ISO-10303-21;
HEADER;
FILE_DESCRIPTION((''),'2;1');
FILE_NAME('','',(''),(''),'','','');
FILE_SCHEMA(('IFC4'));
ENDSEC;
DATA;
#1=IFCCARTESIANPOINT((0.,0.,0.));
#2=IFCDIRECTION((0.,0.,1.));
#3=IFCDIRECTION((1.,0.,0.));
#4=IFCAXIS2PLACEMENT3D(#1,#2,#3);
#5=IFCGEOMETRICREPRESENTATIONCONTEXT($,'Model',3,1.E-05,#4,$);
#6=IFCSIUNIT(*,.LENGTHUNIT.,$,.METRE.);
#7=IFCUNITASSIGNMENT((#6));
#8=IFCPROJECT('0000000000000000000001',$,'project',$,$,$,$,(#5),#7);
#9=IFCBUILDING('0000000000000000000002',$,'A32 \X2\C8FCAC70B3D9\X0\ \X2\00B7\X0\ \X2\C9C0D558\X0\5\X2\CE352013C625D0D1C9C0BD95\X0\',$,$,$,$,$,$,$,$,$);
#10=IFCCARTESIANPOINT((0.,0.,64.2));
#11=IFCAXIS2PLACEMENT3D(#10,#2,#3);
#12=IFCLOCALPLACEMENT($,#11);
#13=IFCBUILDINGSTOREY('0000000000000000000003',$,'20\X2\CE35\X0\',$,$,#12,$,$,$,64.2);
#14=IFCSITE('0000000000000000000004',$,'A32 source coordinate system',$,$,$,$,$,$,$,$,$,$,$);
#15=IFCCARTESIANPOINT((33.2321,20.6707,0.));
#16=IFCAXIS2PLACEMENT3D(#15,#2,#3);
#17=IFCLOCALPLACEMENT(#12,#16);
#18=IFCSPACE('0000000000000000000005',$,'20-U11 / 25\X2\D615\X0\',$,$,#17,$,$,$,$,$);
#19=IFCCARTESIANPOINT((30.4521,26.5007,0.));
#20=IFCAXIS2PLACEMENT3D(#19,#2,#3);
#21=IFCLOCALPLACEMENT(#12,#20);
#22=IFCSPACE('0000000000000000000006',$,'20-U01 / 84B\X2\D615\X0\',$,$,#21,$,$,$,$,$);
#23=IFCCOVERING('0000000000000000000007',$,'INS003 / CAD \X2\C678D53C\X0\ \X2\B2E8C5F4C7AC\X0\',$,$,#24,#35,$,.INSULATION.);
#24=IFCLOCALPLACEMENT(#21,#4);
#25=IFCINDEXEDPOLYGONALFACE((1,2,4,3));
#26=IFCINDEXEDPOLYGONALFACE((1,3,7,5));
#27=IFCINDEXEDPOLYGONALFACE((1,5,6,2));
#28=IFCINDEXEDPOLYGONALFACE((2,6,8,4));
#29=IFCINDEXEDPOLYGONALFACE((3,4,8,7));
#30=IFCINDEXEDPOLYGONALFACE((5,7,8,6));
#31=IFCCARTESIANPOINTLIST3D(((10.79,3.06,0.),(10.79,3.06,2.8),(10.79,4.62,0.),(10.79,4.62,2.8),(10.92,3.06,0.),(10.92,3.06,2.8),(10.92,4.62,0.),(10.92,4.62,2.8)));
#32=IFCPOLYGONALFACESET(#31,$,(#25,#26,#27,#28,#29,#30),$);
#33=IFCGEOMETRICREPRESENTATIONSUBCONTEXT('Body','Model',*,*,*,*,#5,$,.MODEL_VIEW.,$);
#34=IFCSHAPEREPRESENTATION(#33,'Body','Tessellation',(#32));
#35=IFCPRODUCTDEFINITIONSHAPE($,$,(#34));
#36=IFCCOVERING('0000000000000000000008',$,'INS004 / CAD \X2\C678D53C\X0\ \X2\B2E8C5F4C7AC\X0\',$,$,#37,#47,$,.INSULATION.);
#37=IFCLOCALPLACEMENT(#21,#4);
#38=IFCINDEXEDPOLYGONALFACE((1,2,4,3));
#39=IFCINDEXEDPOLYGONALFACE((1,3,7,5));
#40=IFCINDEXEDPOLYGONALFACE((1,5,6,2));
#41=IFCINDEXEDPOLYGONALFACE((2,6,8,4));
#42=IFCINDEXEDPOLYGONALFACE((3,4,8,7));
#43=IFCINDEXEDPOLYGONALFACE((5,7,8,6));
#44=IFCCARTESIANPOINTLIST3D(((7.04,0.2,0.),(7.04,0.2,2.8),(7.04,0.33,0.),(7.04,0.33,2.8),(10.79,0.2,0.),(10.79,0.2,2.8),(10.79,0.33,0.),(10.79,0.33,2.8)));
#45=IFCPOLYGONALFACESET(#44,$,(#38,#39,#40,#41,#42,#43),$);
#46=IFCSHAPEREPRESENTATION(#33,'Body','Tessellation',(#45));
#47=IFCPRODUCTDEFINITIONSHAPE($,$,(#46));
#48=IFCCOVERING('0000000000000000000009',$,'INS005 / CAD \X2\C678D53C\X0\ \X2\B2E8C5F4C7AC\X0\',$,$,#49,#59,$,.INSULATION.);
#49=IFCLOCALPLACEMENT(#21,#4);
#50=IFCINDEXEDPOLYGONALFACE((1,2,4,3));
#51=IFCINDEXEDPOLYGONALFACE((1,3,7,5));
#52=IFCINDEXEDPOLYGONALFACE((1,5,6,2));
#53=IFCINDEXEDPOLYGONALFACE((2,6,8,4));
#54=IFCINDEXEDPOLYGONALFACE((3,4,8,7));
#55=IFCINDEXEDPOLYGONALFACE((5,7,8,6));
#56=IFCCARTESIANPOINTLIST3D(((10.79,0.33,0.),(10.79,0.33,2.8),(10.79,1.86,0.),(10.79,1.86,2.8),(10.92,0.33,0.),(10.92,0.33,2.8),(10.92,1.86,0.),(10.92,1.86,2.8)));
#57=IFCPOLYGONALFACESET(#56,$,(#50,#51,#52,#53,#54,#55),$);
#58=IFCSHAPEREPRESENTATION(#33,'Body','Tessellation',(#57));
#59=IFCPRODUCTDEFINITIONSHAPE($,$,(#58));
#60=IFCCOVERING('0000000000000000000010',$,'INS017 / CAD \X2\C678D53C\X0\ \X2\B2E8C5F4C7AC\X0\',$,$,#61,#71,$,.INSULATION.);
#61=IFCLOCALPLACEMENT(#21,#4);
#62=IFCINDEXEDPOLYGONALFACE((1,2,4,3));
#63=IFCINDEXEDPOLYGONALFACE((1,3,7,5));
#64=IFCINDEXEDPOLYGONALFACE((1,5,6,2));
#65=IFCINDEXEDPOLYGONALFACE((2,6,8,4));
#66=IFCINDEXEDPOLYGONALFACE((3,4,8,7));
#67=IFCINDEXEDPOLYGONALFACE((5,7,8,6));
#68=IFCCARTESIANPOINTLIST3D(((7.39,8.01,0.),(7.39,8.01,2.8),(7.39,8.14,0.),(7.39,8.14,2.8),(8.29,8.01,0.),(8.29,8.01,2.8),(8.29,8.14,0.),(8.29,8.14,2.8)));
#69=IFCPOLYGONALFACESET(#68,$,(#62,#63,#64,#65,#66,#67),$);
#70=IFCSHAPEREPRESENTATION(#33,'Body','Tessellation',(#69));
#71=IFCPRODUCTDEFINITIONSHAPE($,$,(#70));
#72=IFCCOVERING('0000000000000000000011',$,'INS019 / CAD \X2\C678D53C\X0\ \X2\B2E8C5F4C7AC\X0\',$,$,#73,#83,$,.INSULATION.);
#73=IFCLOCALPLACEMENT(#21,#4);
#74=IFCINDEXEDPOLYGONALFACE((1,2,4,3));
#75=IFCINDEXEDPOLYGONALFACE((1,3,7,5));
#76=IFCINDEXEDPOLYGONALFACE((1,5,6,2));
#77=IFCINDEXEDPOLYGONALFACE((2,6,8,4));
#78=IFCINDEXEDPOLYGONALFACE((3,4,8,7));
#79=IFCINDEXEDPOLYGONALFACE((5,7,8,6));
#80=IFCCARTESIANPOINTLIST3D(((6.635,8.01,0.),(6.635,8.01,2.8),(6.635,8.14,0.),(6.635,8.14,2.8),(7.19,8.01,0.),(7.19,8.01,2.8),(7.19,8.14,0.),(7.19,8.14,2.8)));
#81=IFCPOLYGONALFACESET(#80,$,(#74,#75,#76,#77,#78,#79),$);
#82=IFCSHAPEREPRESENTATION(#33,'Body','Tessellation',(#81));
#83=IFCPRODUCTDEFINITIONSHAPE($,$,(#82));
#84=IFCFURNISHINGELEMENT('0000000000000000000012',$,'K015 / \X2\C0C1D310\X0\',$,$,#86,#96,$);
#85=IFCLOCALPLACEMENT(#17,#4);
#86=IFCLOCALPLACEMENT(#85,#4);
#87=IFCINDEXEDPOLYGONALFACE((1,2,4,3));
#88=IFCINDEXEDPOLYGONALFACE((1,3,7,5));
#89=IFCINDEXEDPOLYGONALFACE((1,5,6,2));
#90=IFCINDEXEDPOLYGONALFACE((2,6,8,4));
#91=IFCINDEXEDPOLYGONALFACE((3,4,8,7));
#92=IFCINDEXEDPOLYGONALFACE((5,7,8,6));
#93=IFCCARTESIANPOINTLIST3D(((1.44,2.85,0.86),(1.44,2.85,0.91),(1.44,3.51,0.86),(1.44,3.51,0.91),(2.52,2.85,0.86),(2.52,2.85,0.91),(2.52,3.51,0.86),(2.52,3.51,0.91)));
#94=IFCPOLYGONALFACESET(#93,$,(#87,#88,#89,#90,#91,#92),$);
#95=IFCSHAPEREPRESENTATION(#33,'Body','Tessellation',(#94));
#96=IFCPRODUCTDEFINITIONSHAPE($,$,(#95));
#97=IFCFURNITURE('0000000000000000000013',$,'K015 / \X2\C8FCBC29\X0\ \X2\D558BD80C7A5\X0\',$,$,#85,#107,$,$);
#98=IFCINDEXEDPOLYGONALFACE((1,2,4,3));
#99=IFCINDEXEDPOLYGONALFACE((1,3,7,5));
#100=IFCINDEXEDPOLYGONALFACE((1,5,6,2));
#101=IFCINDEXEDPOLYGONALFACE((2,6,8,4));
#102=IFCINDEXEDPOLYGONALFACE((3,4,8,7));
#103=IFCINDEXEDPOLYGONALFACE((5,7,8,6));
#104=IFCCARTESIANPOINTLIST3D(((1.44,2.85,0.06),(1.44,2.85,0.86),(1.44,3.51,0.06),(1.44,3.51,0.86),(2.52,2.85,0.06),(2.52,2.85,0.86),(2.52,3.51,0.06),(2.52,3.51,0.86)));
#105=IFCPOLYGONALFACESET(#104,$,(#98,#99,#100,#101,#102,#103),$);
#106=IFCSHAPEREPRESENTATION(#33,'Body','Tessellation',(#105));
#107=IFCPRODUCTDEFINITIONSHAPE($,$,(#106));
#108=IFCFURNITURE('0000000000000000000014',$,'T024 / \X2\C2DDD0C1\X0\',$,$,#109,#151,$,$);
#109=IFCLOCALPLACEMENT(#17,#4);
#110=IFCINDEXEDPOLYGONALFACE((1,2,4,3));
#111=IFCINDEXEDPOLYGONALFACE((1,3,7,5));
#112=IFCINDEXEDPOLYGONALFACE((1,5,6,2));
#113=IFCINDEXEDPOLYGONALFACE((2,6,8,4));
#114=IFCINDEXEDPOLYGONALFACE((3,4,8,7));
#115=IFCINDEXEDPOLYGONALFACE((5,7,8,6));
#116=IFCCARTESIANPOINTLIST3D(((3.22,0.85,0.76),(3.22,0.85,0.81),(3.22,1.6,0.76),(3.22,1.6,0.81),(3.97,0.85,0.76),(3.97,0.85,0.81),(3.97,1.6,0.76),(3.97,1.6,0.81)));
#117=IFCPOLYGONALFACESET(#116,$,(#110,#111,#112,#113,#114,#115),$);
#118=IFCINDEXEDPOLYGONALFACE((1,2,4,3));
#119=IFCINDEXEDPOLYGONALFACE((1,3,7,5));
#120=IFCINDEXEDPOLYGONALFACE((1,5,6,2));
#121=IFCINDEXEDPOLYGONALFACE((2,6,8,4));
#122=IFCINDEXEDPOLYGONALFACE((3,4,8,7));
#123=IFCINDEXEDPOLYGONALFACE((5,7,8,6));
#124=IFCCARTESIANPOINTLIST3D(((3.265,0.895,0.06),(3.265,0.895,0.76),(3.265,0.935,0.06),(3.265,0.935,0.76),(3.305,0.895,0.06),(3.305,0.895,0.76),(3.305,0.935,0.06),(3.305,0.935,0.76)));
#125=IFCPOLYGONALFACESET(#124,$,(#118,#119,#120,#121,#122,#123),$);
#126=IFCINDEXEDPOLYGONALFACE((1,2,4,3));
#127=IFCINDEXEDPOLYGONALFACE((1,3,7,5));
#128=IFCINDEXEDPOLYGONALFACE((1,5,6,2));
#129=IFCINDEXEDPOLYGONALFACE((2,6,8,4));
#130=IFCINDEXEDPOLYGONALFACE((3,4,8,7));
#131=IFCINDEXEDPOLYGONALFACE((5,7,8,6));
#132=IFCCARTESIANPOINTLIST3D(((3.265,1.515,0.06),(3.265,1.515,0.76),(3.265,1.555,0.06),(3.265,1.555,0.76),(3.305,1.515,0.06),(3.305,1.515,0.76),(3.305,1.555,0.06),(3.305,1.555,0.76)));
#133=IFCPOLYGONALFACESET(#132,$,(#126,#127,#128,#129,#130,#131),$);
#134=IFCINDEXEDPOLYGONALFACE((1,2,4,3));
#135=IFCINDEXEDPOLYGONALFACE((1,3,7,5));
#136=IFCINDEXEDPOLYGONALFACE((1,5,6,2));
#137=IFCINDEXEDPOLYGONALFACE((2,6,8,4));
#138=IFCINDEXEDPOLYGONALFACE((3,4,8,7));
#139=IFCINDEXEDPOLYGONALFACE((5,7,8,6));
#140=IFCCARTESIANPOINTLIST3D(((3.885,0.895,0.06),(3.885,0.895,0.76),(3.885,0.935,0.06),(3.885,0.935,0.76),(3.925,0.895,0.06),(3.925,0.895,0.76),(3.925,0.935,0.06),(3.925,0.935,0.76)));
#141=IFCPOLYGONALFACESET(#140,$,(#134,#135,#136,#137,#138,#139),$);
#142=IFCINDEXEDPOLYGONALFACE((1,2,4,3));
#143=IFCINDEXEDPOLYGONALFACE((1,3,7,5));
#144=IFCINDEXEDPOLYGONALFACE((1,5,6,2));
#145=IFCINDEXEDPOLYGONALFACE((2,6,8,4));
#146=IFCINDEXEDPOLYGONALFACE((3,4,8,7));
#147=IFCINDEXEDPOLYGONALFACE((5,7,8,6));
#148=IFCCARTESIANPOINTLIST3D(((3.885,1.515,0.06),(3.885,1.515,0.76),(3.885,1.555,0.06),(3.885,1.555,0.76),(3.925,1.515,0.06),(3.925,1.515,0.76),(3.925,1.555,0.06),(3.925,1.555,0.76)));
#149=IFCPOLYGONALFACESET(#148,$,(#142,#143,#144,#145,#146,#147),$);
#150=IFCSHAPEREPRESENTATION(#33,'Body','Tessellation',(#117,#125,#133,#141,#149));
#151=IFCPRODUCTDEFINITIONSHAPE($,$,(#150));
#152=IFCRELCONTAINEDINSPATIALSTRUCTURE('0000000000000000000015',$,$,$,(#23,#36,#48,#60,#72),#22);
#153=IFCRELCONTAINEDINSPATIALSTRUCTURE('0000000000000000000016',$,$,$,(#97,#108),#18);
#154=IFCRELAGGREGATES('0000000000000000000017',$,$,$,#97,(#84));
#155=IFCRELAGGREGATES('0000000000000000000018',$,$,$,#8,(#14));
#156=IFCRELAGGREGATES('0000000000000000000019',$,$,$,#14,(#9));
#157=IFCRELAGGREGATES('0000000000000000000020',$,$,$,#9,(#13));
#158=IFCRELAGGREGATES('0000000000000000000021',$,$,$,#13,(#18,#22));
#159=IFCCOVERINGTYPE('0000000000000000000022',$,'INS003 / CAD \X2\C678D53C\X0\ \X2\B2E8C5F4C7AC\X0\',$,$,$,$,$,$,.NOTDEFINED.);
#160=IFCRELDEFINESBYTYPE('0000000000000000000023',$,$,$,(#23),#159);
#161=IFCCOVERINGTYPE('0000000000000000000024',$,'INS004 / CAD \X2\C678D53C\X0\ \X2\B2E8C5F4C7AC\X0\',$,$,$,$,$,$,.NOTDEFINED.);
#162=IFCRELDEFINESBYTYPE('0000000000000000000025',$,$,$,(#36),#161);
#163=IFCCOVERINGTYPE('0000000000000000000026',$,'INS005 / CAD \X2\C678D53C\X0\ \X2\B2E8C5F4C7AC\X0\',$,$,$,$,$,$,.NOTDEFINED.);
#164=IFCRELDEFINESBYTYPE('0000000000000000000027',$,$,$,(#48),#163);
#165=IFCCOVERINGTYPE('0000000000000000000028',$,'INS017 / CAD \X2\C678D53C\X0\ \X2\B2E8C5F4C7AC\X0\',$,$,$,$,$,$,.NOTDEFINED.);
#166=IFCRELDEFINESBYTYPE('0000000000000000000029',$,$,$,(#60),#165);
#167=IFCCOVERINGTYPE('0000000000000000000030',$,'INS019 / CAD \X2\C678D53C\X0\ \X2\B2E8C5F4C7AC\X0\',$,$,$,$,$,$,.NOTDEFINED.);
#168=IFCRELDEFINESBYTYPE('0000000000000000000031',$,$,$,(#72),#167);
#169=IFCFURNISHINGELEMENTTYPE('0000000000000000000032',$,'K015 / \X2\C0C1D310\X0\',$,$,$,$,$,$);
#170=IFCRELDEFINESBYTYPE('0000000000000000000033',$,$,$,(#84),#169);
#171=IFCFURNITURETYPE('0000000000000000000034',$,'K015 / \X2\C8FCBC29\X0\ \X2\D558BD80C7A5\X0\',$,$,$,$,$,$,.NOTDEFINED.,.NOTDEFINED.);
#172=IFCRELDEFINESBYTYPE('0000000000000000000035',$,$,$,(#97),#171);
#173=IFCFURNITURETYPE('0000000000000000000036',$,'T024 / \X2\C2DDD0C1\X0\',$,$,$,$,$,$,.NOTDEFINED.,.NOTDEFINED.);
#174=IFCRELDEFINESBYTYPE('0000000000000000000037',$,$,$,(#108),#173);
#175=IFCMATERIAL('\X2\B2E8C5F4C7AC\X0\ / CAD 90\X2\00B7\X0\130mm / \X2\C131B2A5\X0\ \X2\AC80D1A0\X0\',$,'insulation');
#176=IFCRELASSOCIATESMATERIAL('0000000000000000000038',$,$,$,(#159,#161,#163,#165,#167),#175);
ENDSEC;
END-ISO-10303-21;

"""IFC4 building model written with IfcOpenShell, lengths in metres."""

from ifc_helpers import new_model, si_unit, frame, origin, origin_with_axes, place, context, subcontext, project, spatial, polyline, outline, extrude, source, transform, mapped, material, type_object, type_shapes, element, aggregate, save


model = new_model("IFC4")

# Units and contexts
model_context = context("Model", 3, precision=1e-05, world=origin_with_axes())
body_context = subcontext(model_context, "Body", "Model", "MODEL_VIEW")
ifc_project = project(units=[si_unit("LENGTHUNIT", "METRE")], contexts=[model_context])

# Site, building, storey, space
site = spatial("IfcSite", under=ifc_project, Name="A32 source coordinate system")
building = spatial("IfcBuilding", under=site, Name="A32 주거동 · 지하5층–옥탑지붕")
storey_placement = place(None, frame((0.0, 0.0, 64.2), z_axis=(0.0, 0.0, 1.0), x_axis=(1.0, 0.0, 0.0)))
storey = spatial("IfcBuildingStorey", under=building, at=storey_placement, Name="20층", Elevation=64.2)
space_1_placement = place(storey_placement, frame((33.2321, 20.6707, 0.0), z_axis=(0.0, 0.0, 1.0), x_axis=(1.0, 0.0, 0.0)))
space_1 = spatial("IfcSpace", under=storey, at=space_1_placement, Name="20-U11 / 25형")

# Shared definitions
space_2_placement = place(storey_placement, frame((30.4521, 26.5007, 0.0), z_axis=(0.0, 0.0, 1.0), x_axis=(1.0, 0.0, 0.0)))
space_2 = spatial("IfcSpace", under=storey, at=space_2_placement, Name="20-U01 / 84B형")

# Coverings
ifc_material = material(Name="단열재 / CAD 90·130mm / 성능 검토", Category="insulation")
covering_type_1 = type_object("IfcCoveringType", Name="INS003 / CAD 외피 단열재", PredefinedType="NOTDEFINED", material=ifc_material)
shared_shape_1 = source(origin(), body_context, "Body", "SweptSolid", [
    extrude(outline(polyline([(10.79, 3.06), (10.79, 4.62), (10.92, 4.62), (10.92, 3.06), (10.79, 3.06)])), origin(), (0.0, 0.0, 1.0), 2.8),
])
type_shapes(covering_type_1, [shared_shape_1])
covering_1_placement = place(space_2_placement, origin_with_axes())
element("IfcCovering", 1, at=covering_1_placement, inside=space_2, type_object=covering_type_1, Name="INS003 / CAD 외피 단열재", PredefinedType="INSULATION", context=body_context, shape_type="MappedRepresentation", body=[
    mapped(shared_shape_1, transform((0.0, 0.0, 0.0), scale=1.0)),
])
covering_type_2 = type_object("IfcCoveringType", Name="INS004 / CAD 외피 단열재", PredefinedType="NOTDEFINED", material=ifc_material)
shared_shape_2 = source(origin(), body_context, "Body", "SweptSolid", [
    extrude(outline(polyline([(7.04, 0.33), (10.79, 0.33), (10.79, 0.2), (7.04, 0.2), (7.04, 0.33)])), origin(), (0.0, 0.0, 1.0), 2.8),
])
type_shapes(covering_type_2, [shared_shape_2])
covering_2_placement = place(space_2_placement, origin_with_axes())
element("IfcCovering", 2, at=covering_2_placement, inside=space_2, type_object=covering_type_2, Name="INS004 / CAD 외피 단열재", PredefinedType="INSULATION", context=body_context, shape_type="MappedRepresentation", body=[
    mapped(shared_shape_2, transform((0.0, 0.0, 0.0), scale=1.0)),
])
covering_type_3 = type_object("IfcCoveringType", Name="INS005 / CAD 외피 단열재", PredefinedType="NOTDEFINED", material=ifc_material)
shared_shape_3 = source(origin(), body_context, "Body", "SweptSolid", [
    extrude(outline(polyline([(10.79, 0.33), (10.79, 1.86), (10.92, 1.86), (10.92, 0.33), (10.79, 0.33)])), origin(), (0.0, 0.0, 1.0), 2.8),
])
type_shapes(covering_type_3, [shared_shape_3])
covering_3_placement = place(space_2_placement, origin_with_axes())
element("IfcCovering", 3, at=covering_3_placement, inside=space_2, type_object=covering_type_3, Name="INS005 / CAD 외피 단열재", PredefinedType="INSULATION", context=body_context, shape_type="MappedRepresentation", body=[
    mapped(shared_shape_3, transform((0.0, 0.0, 0.0), scale=1.0)),
])
covering_type_4 = type_object("IfcCoveringType", Name="INS017 / CAD 외피 단열재", PredefinedType="NOTDEFINED", material=ifc_material)
shared_shape_4 = source(origin(), body_context, "Body", "SweptSolid", [
    extrude(outline(polyline([(8.29, 8.01), (7.39, 8.01), (7.39, 8.14), (8.29, 8.14), (8.29, 8.01)])), origin(), (0.0, 0.0, 1.0), 2.8),
])
type_shapes(covering_type_4, [shared_shape_4])
covering_4_placement = place(space_2_placement, origin_with_axes())
element("IfcCovering", 4, at=covering_4_placement, inside=space_2, type_object=covering_type_4, Name="INS017 / CAD 외피 단열재", PredefinedType="INSULATION", context=body_context, shape_type="MappedRepresentation", body=[
    mapped(shared_shape_4, transform((0.0, 0.0, 0.0), scale=1.0)),
])
covering_type_5 = type_object("IfcCoveringType", Name="INS019 / CAD 외피 단열재", PredefinedType="NOTDEFINED", material=ifc_material)
shared_shape_5 = source(origin(), body_context, "Body", "SweptSolid", [
    extrude(outline(polyline([(6.635, 8.01), (6.635, 8.14), (7.19, 8.14), (7.19, 8.01), (6.635, 8.01)])), origin(), (0.0, 0.0, 1.0), 2.8),
])
type_shapes(covering_type_5, [shared_shape_5])
covering_5_placement = place(space_2_placement, origin_with_axes())
element("IfcCovering", 5, at=covering_5_placement, inside=space_2, type_object=covering_type_5, Name="INS019 / CAD 외피 단열재", PredefinedType="INSULATION", context=body_context, shape_type="MappedRepresentation", body=[
    mapped(shared_shape_5, transform((0.0, 0.0, 0.0), scale=1.0)),
])

# Furnishing element
furnishing_element_type_1 = type_object("IfcFurnishingElementType", Name="K015 / 상판")
shared_shape_6 = source(origin(), body_context, "Body", "SweptSolid", [
    extrude(outline(polyline([(2.52, 2.85), (1.44, 2.85), (1.44, 3.51), (2.52, 3.51), (2.52, 2.85)])), frame((0.0, 0.0, 0.86)), (0.0, 0.0, 1.0), 0.05),
])
type_shapes(furnishing_element_type_1, [shared_shape_6])
furniture_1_placement = place(space_1_placement, origin_with_axes())
furnishing_1_placement = place(furniture_1_placement, origin_with_axes())
furnishing_1 = element("IfcFurnishingElement", 6, at=furnishing_1_placement, type_object=furnishing_element_type_1, Name="K015 / 상판", context=body_context, shape_type="MappedRepresentation", body=[
    mapped(shared_shape_6, transform((0.0, 0.0, 0.0), scale=1.0)),
])

# Furniture
furniture_type_1 = type_object("IfcFurnitureType", Name="K015 / 주방 하부장", AssemblyPlace="NOTDEFINED", PredefinedType="NOTDEFINED")
shared_shape_7 = source(origin(), body_context, "Body", "SweptSolid", [
    extrude(outline(polyline([(2.52, 3.51), (2.52, 2.85), (1.44, 2.85), (1.44, 3.51), (2.52, 3.51)])), frame((0.0, 0.0, 0.06)), (0.0, 0.0, 1.0), 0.8),
])
type_shapes(furniture_type_1, [shared_shape_7])
furniture_1 = element("IfcFurniture", 7, at=furniture_1_placement, inside=space_1, type_object=furniture_type_1, Name="K015 / 주방 하부장", context=body_context, shape_type="MappedRepresentation", body=[
    mapped(shared_shape_7, transform((0.0, 0.0, 0.0), scale=1.0)),
])
aggregate(furniture_1, [furnishing_1])
furniture_type_2 = type_object("IfcFurnitureType", Name="T024 / 식탁", AssemblyPlace="NOTDEFINED", PredefinedType="NOTDEFINED")
shared_shape_8 = source(origin(), body_context, "Body", "SweptSolid", [
    extrude(outline(polyline([(3.22, 0.85), (3.22, 1.6), (3.97, 1.6), (3.97, 0.85), (3.22, 0.85)])), frame((0.0, 0.0, 0.76)), (0.0, 0.0, 1.0), 0.05),
    extrude(outline(polyline([(3.265, 0.895), (3.265, 0.935), (3.305, 0.935), (3.305, 0.895), (3.265, 0.895)])), frame((0.0, 0.0, 0.06)), (0.0, 0.0, 1.0), 0.7),
    extrude(outline(polyline([(3.265, 1.515), (3.265, 1.555), (3.305, 1.555), (3.305, 1.515), (3.265, 1.515)])), frame((0.0, 0.0, 0.06)), (0.0, 0.0, 1.0), 0.7),
    extrude(outline(polyline([(3.885, 0.895), (3.885, 0.935), (3.925, 0.935), (3.925, 0.895), (3.885, 0.895)])), frame((0.0, 0.0, 0.06)), (0.0, 0.0, 1.0), 0.7),
    extrude(outline(polyline([(3.885, 1.515), (3.885, 1.555), (3.925, 1.555), (3.925, 1.515), (3.885, 1.515)])), frame((0.0, 0.0, 0.06)), (0.0, 0.0, 1.0), 0.7),
])
type_shapes(furniture_type_2, [shared_shape_8])
furniture_2_placement = place(space_1_placement, origin_with_axes())
element("IfcFurniture", 8, at=furniture_2_placement, inside=space_1, type_object=furniture_type_2, Name="T024 / 식탁", context=body_context, shape_type="MappedRepresentation", body=[
    mapped(shared_shape_8, transform((0.0, 0.0, 0.0), scale=1.0)),
])

save(model, "model.ifc")
